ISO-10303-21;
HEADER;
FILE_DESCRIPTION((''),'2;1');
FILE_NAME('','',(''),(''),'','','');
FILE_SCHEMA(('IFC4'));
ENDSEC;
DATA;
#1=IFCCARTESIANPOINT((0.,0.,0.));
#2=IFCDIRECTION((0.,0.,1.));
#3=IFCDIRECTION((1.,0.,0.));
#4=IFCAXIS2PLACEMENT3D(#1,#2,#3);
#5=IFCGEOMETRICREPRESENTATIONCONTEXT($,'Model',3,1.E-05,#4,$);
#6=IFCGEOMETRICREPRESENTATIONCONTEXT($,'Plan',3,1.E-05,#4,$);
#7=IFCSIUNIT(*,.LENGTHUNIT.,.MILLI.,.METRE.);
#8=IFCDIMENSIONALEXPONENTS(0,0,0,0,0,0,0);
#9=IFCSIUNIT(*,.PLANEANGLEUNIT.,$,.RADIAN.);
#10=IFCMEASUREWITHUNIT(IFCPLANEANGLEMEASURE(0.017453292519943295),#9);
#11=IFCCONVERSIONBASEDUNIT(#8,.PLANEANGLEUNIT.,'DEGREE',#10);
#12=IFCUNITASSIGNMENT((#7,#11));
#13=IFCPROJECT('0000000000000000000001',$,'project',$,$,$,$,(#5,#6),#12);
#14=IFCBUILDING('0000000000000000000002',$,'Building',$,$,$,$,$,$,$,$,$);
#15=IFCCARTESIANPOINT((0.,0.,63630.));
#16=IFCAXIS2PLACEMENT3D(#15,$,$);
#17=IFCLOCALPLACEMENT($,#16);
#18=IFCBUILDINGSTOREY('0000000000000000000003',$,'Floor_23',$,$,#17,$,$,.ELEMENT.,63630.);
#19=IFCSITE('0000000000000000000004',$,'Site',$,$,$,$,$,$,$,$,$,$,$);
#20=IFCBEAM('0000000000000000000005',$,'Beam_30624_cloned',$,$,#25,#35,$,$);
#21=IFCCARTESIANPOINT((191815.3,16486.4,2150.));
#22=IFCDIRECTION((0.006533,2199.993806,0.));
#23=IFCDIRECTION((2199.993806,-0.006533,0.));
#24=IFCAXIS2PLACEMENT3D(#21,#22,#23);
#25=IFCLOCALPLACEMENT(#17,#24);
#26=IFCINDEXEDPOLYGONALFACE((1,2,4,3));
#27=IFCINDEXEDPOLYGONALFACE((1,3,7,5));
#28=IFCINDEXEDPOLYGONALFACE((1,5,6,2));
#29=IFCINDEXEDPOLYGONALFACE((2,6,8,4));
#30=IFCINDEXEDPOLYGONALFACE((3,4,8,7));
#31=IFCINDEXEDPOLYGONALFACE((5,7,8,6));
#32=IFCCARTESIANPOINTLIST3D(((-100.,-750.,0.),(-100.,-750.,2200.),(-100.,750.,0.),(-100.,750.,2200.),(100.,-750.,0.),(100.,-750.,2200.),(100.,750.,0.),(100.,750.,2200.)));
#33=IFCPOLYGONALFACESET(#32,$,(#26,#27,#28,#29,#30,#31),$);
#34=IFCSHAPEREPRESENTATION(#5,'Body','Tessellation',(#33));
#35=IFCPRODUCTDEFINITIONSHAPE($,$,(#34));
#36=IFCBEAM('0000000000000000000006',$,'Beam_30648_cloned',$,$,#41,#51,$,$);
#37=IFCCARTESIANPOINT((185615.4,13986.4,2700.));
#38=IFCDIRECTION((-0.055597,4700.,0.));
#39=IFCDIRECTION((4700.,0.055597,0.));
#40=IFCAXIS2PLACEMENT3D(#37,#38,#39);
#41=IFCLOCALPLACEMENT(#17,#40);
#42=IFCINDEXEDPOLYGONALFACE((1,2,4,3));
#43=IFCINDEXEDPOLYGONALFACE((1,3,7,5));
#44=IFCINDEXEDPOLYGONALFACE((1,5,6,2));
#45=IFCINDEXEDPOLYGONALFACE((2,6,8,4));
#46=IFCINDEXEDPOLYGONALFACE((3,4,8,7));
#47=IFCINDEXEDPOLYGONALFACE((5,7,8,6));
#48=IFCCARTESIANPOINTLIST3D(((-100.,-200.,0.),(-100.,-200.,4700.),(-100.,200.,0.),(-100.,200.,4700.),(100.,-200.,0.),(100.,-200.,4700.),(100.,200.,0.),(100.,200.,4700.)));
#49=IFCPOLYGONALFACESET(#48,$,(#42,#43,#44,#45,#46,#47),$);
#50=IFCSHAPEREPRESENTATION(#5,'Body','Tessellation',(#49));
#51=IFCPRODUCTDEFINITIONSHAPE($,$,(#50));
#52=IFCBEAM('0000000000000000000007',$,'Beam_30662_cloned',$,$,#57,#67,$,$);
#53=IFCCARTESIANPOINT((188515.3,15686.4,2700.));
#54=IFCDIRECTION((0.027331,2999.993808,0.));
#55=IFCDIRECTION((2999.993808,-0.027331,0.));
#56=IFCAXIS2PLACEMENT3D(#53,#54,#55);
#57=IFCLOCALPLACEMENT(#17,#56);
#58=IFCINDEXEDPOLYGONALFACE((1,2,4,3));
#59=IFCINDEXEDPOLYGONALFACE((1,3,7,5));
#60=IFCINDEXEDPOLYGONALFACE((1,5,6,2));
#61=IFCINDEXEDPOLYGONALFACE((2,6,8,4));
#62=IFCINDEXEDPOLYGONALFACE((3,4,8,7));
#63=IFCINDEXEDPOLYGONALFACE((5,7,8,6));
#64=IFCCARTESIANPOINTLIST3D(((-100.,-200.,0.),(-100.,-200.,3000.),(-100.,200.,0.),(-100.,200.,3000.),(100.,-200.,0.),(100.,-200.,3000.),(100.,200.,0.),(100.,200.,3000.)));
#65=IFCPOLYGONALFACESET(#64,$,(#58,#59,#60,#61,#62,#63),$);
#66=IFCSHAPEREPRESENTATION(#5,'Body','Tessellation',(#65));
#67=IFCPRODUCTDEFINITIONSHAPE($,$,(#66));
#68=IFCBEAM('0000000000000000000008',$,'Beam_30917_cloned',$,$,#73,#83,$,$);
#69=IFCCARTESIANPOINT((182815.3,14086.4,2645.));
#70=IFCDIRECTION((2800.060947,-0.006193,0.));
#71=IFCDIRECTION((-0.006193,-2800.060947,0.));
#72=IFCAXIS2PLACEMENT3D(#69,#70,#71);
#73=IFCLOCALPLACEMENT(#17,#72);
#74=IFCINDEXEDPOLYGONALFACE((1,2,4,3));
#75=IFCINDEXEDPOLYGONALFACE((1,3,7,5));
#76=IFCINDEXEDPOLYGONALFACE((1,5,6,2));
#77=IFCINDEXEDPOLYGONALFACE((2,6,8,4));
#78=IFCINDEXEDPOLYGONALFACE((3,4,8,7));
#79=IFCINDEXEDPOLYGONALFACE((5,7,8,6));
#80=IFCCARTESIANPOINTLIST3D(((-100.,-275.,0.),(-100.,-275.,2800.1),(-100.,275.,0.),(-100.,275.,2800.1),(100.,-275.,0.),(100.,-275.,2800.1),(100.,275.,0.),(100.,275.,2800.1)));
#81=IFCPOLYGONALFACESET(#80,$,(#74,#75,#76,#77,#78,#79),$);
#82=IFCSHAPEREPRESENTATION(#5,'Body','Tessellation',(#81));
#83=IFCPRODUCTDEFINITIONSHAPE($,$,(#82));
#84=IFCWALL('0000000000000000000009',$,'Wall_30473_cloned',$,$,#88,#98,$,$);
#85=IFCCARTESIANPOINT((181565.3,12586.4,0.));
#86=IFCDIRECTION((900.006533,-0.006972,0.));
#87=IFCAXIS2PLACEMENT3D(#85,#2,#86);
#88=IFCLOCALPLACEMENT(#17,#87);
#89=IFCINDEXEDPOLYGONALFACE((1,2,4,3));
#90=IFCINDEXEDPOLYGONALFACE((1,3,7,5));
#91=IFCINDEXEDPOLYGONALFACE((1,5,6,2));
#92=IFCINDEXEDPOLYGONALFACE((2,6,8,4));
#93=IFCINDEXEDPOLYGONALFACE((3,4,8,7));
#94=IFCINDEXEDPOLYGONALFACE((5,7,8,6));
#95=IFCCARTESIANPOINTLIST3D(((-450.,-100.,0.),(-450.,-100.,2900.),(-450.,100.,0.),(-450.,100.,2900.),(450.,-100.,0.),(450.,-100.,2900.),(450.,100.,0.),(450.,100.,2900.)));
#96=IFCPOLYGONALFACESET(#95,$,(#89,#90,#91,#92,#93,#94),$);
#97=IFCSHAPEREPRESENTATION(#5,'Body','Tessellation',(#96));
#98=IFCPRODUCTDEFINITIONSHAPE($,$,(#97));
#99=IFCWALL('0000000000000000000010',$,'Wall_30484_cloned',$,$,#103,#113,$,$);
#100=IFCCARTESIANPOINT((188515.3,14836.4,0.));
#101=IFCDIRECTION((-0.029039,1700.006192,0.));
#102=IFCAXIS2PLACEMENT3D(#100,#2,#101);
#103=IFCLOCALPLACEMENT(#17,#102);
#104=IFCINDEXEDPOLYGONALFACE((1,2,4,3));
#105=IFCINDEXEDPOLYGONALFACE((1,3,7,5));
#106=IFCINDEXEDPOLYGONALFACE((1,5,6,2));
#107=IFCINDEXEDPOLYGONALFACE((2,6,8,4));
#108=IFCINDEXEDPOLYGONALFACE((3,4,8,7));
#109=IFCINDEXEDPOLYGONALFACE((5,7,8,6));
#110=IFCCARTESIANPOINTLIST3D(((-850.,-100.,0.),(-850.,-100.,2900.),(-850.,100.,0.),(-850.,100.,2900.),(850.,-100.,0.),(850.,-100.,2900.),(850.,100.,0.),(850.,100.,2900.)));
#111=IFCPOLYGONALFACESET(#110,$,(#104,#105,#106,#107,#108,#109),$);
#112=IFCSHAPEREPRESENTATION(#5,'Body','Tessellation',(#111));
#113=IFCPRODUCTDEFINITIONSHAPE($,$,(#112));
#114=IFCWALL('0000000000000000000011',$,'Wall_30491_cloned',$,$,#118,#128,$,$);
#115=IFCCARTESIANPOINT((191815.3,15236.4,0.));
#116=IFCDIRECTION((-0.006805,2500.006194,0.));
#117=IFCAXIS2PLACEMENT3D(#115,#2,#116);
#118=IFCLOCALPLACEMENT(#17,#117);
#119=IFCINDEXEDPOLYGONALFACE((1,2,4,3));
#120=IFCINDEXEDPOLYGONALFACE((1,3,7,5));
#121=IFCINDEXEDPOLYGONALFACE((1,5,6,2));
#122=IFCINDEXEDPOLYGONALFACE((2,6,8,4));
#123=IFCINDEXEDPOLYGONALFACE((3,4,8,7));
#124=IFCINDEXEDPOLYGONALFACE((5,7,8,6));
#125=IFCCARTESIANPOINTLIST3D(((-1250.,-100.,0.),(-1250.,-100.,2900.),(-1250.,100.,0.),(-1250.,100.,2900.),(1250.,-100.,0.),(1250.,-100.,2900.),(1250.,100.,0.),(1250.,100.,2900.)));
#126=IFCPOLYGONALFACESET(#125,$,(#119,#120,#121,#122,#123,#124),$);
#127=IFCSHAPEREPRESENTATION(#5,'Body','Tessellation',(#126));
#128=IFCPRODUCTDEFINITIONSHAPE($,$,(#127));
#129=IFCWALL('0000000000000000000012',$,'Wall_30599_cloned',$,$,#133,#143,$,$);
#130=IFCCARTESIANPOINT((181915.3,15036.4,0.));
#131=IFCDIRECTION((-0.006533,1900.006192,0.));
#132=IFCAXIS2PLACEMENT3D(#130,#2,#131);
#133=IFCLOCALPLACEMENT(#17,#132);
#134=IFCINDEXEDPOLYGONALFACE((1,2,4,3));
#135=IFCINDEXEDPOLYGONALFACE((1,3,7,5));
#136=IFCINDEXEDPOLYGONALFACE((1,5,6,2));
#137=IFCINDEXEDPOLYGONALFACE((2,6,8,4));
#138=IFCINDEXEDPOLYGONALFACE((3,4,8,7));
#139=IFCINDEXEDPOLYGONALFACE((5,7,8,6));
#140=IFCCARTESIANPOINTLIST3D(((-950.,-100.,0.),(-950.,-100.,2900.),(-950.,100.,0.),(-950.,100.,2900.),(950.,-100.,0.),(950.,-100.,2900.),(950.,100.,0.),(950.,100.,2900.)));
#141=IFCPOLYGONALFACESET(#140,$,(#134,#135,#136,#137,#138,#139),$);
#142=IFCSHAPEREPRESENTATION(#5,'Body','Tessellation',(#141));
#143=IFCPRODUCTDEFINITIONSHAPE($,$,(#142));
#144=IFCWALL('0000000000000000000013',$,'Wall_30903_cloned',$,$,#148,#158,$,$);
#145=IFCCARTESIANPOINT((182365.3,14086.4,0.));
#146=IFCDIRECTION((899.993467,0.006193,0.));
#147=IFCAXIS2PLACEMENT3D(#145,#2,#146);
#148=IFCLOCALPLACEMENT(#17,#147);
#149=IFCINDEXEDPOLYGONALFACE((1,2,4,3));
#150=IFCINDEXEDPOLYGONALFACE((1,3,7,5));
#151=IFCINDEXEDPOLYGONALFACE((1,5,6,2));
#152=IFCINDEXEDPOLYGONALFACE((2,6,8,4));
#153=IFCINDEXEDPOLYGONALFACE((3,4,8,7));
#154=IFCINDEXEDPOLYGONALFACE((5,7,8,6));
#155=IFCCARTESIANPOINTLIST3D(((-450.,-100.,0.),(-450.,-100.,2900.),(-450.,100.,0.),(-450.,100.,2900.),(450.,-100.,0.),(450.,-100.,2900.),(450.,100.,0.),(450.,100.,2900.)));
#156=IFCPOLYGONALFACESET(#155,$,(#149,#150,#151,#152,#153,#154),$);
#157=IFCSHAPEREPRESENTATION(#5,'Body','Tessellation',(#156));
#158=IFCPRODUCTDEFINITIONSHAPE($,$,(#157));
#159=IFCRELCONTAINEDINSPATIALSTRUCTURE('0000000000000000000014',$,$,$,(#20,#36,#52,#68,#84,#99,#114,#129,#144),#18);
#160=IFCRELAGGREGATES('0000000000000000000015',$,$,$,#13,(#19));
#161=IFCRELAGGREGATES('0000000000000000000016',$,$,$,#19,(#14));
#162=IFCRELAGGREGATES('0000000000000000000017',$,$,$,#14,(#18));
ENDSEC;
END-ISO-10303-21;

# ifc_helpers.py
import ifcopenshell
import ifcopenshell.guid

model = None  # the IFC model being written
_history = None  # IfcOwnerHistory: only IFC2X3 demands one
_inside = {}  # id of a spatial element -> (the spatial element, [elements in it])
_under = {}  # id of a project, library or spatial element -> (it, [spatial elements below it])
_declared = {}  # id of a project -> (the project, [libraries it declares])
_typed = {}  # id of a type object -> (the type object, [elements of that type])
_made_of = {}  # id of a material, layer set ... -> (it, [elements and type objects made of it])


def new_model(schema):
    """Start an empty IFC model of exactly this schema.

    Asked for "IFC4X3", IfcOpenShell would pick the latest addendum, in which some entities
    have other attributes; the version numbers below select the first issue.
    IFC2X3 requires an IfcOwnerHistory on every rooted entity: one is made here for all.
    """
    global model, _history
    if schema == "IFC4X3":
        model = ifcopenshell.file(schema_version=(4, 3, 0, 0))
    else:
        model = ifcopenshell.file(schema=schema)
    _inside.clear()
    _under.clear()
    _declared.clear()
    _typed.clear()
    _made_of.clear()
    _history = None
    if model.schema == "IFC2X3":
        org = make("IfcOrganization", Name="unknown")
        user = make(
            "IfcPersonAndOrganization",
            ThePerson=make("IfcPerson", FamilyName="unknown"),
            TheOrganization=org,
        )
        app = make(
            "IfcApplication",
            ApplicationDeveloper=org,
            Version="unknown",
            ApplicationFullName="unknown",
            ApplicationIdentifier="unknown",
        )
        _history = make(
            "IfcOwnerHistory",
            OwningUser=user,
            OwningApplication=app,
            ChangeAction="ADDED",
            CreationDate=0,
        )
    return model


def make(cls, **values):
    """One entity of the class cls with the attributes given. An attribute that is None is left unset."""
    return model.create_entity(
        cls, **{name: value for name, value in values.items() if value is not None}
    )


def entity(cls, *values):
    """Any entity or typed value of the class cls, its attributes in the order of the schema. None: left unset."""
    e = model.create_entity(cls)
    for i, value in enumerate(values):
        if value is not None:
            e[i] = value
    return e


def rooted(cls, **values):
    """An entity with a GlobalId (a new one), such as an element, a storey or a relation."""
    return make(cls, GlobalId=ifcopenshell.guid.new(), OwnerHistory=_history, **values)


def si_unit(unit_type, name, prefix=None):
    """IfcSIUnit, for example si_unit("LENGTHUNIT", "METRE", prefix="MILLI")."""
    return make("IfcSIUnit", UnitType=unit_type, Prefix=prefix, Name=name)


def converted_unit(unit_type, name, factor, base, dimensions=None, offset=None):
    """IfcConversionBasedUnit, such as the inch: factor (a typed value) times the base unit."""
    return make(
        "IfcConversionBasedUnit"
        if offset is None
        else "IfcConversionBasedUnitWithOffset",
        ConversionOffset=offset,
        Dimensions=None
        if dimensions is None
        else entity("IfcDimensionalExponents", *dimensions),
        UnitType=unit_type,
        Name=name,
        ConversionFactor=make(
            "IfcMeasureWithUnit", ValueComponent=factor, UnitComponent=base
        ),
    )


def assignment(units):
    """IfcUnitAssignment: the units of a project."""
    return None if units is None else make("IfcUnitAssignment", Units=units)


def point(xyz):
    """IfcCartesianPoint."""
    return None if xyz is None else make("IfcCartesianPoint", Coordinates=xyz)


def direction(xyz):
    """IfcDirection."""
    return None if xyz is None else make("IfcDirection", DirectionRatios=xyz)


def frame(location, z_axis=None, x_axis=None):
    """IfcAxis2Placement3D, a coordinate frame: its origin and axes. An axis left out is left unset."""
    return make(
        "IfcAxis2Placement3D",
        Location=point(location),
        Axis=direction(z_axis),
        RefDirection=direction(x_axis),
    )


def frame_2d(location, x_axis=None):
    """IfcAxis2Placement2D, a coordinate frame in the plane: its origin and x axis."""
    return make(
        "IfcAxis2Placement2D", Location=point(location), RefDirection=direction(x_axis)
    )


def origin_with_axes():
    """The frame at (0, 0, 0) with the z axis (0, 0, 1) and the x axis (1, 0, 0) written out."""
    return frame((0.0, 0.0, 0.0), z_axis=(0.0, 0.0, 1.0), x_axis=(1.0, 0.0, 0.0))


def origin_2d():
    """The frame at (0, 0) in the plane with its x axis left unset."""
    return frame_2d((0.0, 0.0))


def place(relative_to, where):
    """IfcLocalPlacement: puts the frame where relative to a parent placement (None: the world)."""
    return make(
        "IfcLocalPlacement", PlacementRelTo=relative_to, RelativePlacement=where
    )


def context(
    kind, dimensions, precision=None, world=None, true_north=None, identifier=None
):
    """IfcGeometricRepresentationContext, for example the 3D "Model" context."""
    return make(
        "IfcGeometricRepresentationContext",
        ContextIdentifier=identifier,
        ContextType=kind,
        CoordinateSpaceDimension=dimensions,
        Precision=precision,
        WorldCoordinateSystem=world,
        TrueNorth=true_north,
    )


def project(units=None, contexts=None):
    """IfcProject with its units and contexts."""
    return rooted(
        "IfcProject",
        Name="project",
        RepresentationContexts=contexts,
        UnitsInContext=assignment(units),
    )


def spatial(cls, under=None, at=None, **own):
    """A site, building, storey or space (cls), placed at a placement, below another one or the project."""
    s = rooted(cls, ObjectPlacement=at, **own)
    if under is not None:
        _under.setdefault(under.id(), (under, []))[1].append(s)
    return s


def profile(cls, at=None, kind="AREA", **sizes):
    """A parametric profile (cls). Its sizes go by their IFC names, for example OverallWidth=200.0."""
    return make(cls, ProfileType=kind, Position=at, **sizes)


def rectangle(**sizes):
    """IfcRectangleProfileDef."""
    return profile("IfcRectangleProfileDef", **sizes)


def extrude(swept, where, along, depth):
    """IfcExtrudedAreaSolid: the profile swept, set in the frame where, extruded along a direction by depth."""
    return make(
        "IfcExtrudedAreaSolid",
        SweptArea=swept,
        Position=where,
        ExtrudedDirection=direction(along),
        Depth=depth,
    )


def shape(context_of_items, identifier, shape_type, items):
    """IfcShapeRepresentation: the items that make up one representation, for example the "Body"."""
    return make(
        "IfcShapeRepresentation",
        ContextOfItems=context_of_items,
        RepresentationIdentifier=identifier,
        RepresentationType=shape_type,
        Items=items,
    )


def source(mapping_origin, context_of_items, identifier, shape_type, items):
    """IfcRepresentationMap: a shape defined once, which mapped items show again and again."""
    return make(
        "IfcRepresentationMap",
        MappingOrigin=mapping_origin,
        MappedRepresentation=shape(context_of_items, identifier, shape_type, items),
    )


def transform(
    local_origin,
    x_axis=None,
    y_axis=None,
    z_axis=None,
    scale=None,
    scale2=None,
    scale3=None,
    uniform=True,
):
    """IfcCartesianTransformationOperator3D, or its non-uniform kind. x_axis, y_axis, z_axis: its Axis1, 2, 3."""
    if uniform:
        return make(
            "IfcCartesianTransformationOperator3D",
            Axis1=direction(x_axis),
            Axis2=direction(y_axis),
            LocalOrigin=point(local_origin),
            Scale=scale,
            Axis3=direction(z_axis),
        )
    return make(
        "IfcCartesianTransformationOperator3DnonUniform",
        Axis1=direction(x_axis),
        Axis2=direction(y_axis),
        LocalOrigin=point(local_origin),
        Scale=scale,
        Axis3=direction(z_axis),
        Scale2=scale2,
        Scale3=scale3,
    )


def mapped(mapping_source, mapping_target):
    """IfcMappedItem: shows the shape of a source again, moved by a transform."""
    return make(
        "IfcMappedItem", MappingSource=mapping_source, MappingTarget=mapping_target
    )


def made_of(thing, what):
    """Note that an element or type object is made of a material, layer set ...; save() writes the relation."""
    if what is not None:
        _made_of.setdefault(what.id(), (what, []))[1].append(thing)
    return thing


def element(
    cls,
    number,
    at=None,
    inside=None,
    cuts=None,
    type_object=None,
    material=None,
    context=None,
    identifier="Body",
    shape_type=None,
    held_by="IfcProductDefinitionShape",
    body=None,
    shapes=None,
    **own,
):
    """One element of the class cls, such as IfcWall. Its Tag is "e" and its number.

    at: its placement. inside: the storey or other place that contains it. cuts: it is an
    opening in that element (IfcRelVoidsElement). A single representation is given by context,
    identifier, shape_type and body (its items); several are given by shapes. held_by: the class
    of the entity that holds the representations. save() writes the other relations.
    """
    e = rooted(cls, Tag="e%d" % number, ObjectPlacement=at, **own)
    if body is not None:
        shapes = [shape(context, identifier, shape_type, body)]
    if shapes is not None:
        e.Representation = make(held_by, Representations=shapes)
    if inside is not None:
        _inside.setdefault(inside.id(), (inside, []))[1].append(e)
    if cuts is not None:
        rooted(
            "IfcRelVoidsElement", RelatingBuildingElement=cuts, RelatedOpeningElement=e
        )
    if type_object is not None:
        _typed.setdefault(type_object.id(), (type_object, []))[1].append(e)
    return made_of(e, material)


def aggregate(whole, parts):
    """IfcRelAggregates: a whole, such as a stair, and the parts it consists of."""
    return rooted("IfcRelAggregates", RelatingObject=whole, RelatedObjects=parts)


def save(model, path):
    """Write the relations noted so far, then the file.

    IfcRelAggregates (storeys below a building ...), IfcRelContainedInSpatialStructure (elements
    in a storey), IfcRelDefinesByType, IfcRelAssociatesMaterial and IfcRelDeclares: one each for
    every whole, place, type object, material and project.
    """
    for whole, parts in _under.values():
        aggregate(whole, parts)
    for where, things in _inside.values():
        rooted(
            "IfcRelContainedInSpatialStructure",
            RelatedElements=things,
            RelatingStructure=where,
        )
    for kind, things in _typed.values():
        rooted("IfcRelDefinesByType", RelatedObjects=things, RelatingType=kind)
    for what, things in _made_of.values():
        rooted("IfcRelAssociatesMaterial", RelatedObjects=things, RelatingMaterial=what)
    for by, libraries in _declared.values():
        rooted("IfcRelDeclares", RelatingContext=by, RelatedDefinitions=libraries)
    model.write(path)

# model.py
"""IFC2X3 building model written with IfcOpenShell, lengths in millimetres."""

from ifc_helpers import new_model, entity, si_unit, converted_unit, frame, origin_with_axes, origin_2d, place, context, project, spatial, rectangle, extrude, source, transform, mapped, element, save


model = new_model("IFC2X3")

# Units and contexts
model_context = context("Model", 3, precision=1e-05, world=origin_with_axes())
plan_context = context("Plan", 3, precision=1e-05, world=origin_with_axes())
ifc_project = project(units=[si_unit("LENGTHUNIT", "METRE", prefix="MILLI"), converted_unit("PLANEANGLEUNIT", "DEGREE", entity("IfcPlaneAngleMeasure", 0.017453292519943295), si_unit("PLANEANGLEUNIT", "RADIAN"), dimensions=[0, 0, 0, 0, 0, 0, 0])], contexts=[model_context, plan_context])

# Site, building, storey
site = spatial("IfcSite", under=ifc_project, Name="Site")
building = spatial("IfcBuilding", under=site, Name="Building")
storey_placement = place(None, frame((0.0, 0.0, 63630.0)))
storey = spatial("IfcBuildingStorey", under=building, at=storey_placement, Name="Floor_23", CompositionType="ELEMENT", Elevation=63630.0)

# Beams
shared_shape_1 = source(origin_with_axes(), model_context, "Body", "SweptSolid", [
    extrude(rectangle(XDim=200.0, YDim=1500.0, at=origin_2d()), origin_with_axes(), (0.0, 0.0, 1.0), 2200.0),
])
beam_1_placement = place(storey_placement, frame((191815.3, 16486.4, 2150.0), z_axis=(0.006533, 2199.993806, 0.0), x_axis=(2199.993806, -0.006533, 0.0)))
element("IfcBeam", 1, at=beam_1_placement, inside=storey, Name="Beam_30624_cloned", context=model_context, shape_type="MappedRepresentation", body=[
    mapped(shared_shape_1, transform((0.0, 0.0, 0.0), x_axis=(1.0, 0.0, 0.0), y_axis=(0.0, 1.0, 0.0), z_axis=(0.0, 0.0, 1.0), scale=1.0)),
])
shared_shape_2 = source(origin_with_axes(), model_context, "Body", "SweptSolid", [
    extrude(rectangle(XDim=200.0, YDim=400.0, at=origin_2d()), origin_with_axes(), (0.0, 0.0, 1.0), 4700.0),
])
beam_2_placement = place(storey_placement, frame((185615.4, 13986.4, 2700.0), z_axis=(-0.055597, 4700.0, 0.0), x_axis=(4700.0, 0.055597, 0.0)))
element("IfcBeam", 2, at=beam_2_placement, inside=storey, Name="Beam_30648_cloned", context=model_context, shape_type="MappedRepresentation", body=[
    mapped(shared_shape_2, transform((0.0, 0.0, 0.0), x_axis=(1.0, 0.0, 0.0), y_axis=(0.0, 1.0, 0.0), z_axis=(0.0, 0.0, 1.0), scale=1.0)),
])
shared_shape_3 = source(origin_with_axes(), model_context, "Body", "SweptSolid", [
    extrude(rectangle(XDim=200.0, YDim=400.0, at=origin_2d()), origin_with_axes(), (0.0, 0.0, 1.0), 3000.0),
])
beam_3_placement = place(storey_placement, frame((188515.3, 15686.4, 2700.0), z_axis=(0.027331, 2999.993808, 0.0), x_axis=(2999.993808, -0.027331, 0.0)))
element("IfcBeam", 3, at=beam_3_placement, inside=storey, Name="Beam_30662_cloned", context=model_context, shape_type="MappedRepresentation", body=[
    mapped(shared_shape_3, transform((0.0, 0.0, 0.0), x_axis=(1.0, 0.0, 0.0), y_axis=(0.0, 1.0, 0.0), z_axis=(0.0, 0.0, 1.0), scale=1.0)),
])
shared_shape_4 = source(origin_with_axes(), model_context, "Body", "SweptSolid", [
    extrude(rectangle(XDim=200.0, YDim=550.0, at=origin_2d()), origin_with_axes(), (0.0, 0.0, 1.0), 2800.1),
])
beam_4_placement = place(storey_placement, frame((182815.3, 14086.4, 2645.0), z_axis=(2800.060947, -0.006193, 0.0), x_axis=(-0.006193, -2800.060947, 0.0)))
element("IfcBeam", 4, at=beam_4_placement, inside=storey, Name="Beam_30917_cloned", context=model_context, shape_type="MappedRepresentation", body=[
    mapped(shared_shape_4, transform((0.0, 0.0, 0.0), x_axis=(1.0, 0.0, 0.0), y_axis=(0.0, 1.0, 0.0), z_axis=(0.0, 0.0, 1.0), scale=1.0)),
])

# Walls
shared_shape_5 = source(origin_with_axes(), model_context, "Body", "SweptSolid", [
    extrude(rectangle(XDim=900.0, YDim=200.0, at=origin_2d()), origin_with_axes(), (0.0, 0.0, 1.0), 2900.0),
])
wall_1_placement = place(storey_placement, frame((181565.3, 12586.4, 0.0), z_axis=(0.0, 0.0, 1.0), x_axis=(900.006533, -0.006972, 0.0)))
element("IfcWall", 5, at=wall_1_placement, inside=storey, Name="Wall_30473_cloned", context=model_context, shape_type="MappedRepresentation", body=[
    mapped(shared_shape_5, transform((0.0, 0.0, 0.0), x_axis=(1.0, 0.0, 0.0), y_axis=(0.0, 1.0, 0.0), z_axis=(0.0, 0.0, 1.0), scale=1.0)),
])
shared_shape_6 = source(origin_with_axes(), model_context, "Body", "SweptSolid", [
    extrude(rectangle(XDim=1700.0, YDim=200.0, at=origin_2d()), origin_with_axes(), (0.0, 0.0, 1.0), 2900.0),
])
wall_2_placement = place(storey_placement, frame((188515.3, 14836.4, 0.0), z_axis=(0.0, 0.0, 1.0), x_axis=(-0.029039, 1700.006192, 0.0)))
element("IfcWall", 6, at=wall_2_placement, inside=storey, Name="Wall_30484_cloned", context=model_context, shape_type="MappedRepresentation", body=[
    mapped(shared_shape_6, transform((0.0, 0.0, 0.0), x_axis=(1.0, 0.0, 0.0), y_axis=(0.0, 1.0, 0.0), z_axis=(0.0, 0.0, 1.0), scale=1.0)),
])
shared_shape_7 = source(origin_with_axes(), model_context, "Body", "SweptSolid", [
    extrude(rectangle(XDim=2500.0, YDim=200.0, at=origin_2d()), origin_with_axes(), (0.0, 0.0, 1.0), 2900.0),
])
wall_3_placement = place(storey_placement, frame((191815.3, 15236.4, 0.0), z_axis=(0.0, 0.0, 1.0), x_axis=(-0.006805, 2500.006194, 0.0)))
element("IfcWall", 7, at=wall_3_placement, inside=storey, Name="Wall_30491_cloned", context=model_context, shape_type="MappedRepresentation", body=[
    mapped(shared_shape_7, transform((0.0, 0.0, 0.0), x_axis=(1.0, 0.0, 0.0), y_axis=(0.0, 1.0, 0.0), z_axis=(0.0, 0.0, 1.0), scale=1.0)),
])
shared_shape_8 = source(origin_with_axes(), model_context, "Body", "SweptSolid", [
    extrude(rectangle(XDim=1900.0, YDim=200.0, at=origin_2d()), origin_with_axes(), (0.0, 0.0, 1.0), 2900.0),
])
wall_4_placement = place(storey_placement, frame((181915.3, 15036.4, 0.0), z_axis=(0.0, 0.0, 1.0), x_axis=(-0.006533, 1900.006192, 0.0)))
element("IfcWall", 8, at=wall_4_placement, inside=storey, Name="Wall_30599_cloned", context=model_context, shape_type="MappedRepresentation", body=[
    mapped(shared_shape_8, transform((0.0, 0.0, 0.0), x_axis=(1.0, 0.0, 0.0), y_axis=(0.0, 1.0, 0.0), z_axis=(0.0, 0.0, 1.0), scale=1.0)),
])
shared_shape_9 = source(origin_with_axes(), model_context, "Body", "SweptSolid", [
    extrude(rectangle(XDim=900.0, YDim=200.0, at=origin_2d()), origin_with_axes(), (0.0, 0.0, 1.0), 2900.0),
])
wall_5_placement = place(storey_placement, frame((182365.3, 14086.4, 0.0), z_axis=(0.0, 0.0, 1.0), x_axis=(899.993467, 0.006193, 0.0)))
element("IfcWall", 9, at=wall_5_placement, inside=storey, Name="Wall_30903_cloned", context=model_context, shape_type="MappedRepresentation", body=[
    mapped(shared_shape_9, transform((0.0, 0.0, 0.0), x_axis=(1.0, 0.0, 0.0), y_axis=(0.0, 1.0, 0.0), z_axis=(0.0, 0.0, 1.0), scale=1.0)),
])

save(model, "model.ifc")
